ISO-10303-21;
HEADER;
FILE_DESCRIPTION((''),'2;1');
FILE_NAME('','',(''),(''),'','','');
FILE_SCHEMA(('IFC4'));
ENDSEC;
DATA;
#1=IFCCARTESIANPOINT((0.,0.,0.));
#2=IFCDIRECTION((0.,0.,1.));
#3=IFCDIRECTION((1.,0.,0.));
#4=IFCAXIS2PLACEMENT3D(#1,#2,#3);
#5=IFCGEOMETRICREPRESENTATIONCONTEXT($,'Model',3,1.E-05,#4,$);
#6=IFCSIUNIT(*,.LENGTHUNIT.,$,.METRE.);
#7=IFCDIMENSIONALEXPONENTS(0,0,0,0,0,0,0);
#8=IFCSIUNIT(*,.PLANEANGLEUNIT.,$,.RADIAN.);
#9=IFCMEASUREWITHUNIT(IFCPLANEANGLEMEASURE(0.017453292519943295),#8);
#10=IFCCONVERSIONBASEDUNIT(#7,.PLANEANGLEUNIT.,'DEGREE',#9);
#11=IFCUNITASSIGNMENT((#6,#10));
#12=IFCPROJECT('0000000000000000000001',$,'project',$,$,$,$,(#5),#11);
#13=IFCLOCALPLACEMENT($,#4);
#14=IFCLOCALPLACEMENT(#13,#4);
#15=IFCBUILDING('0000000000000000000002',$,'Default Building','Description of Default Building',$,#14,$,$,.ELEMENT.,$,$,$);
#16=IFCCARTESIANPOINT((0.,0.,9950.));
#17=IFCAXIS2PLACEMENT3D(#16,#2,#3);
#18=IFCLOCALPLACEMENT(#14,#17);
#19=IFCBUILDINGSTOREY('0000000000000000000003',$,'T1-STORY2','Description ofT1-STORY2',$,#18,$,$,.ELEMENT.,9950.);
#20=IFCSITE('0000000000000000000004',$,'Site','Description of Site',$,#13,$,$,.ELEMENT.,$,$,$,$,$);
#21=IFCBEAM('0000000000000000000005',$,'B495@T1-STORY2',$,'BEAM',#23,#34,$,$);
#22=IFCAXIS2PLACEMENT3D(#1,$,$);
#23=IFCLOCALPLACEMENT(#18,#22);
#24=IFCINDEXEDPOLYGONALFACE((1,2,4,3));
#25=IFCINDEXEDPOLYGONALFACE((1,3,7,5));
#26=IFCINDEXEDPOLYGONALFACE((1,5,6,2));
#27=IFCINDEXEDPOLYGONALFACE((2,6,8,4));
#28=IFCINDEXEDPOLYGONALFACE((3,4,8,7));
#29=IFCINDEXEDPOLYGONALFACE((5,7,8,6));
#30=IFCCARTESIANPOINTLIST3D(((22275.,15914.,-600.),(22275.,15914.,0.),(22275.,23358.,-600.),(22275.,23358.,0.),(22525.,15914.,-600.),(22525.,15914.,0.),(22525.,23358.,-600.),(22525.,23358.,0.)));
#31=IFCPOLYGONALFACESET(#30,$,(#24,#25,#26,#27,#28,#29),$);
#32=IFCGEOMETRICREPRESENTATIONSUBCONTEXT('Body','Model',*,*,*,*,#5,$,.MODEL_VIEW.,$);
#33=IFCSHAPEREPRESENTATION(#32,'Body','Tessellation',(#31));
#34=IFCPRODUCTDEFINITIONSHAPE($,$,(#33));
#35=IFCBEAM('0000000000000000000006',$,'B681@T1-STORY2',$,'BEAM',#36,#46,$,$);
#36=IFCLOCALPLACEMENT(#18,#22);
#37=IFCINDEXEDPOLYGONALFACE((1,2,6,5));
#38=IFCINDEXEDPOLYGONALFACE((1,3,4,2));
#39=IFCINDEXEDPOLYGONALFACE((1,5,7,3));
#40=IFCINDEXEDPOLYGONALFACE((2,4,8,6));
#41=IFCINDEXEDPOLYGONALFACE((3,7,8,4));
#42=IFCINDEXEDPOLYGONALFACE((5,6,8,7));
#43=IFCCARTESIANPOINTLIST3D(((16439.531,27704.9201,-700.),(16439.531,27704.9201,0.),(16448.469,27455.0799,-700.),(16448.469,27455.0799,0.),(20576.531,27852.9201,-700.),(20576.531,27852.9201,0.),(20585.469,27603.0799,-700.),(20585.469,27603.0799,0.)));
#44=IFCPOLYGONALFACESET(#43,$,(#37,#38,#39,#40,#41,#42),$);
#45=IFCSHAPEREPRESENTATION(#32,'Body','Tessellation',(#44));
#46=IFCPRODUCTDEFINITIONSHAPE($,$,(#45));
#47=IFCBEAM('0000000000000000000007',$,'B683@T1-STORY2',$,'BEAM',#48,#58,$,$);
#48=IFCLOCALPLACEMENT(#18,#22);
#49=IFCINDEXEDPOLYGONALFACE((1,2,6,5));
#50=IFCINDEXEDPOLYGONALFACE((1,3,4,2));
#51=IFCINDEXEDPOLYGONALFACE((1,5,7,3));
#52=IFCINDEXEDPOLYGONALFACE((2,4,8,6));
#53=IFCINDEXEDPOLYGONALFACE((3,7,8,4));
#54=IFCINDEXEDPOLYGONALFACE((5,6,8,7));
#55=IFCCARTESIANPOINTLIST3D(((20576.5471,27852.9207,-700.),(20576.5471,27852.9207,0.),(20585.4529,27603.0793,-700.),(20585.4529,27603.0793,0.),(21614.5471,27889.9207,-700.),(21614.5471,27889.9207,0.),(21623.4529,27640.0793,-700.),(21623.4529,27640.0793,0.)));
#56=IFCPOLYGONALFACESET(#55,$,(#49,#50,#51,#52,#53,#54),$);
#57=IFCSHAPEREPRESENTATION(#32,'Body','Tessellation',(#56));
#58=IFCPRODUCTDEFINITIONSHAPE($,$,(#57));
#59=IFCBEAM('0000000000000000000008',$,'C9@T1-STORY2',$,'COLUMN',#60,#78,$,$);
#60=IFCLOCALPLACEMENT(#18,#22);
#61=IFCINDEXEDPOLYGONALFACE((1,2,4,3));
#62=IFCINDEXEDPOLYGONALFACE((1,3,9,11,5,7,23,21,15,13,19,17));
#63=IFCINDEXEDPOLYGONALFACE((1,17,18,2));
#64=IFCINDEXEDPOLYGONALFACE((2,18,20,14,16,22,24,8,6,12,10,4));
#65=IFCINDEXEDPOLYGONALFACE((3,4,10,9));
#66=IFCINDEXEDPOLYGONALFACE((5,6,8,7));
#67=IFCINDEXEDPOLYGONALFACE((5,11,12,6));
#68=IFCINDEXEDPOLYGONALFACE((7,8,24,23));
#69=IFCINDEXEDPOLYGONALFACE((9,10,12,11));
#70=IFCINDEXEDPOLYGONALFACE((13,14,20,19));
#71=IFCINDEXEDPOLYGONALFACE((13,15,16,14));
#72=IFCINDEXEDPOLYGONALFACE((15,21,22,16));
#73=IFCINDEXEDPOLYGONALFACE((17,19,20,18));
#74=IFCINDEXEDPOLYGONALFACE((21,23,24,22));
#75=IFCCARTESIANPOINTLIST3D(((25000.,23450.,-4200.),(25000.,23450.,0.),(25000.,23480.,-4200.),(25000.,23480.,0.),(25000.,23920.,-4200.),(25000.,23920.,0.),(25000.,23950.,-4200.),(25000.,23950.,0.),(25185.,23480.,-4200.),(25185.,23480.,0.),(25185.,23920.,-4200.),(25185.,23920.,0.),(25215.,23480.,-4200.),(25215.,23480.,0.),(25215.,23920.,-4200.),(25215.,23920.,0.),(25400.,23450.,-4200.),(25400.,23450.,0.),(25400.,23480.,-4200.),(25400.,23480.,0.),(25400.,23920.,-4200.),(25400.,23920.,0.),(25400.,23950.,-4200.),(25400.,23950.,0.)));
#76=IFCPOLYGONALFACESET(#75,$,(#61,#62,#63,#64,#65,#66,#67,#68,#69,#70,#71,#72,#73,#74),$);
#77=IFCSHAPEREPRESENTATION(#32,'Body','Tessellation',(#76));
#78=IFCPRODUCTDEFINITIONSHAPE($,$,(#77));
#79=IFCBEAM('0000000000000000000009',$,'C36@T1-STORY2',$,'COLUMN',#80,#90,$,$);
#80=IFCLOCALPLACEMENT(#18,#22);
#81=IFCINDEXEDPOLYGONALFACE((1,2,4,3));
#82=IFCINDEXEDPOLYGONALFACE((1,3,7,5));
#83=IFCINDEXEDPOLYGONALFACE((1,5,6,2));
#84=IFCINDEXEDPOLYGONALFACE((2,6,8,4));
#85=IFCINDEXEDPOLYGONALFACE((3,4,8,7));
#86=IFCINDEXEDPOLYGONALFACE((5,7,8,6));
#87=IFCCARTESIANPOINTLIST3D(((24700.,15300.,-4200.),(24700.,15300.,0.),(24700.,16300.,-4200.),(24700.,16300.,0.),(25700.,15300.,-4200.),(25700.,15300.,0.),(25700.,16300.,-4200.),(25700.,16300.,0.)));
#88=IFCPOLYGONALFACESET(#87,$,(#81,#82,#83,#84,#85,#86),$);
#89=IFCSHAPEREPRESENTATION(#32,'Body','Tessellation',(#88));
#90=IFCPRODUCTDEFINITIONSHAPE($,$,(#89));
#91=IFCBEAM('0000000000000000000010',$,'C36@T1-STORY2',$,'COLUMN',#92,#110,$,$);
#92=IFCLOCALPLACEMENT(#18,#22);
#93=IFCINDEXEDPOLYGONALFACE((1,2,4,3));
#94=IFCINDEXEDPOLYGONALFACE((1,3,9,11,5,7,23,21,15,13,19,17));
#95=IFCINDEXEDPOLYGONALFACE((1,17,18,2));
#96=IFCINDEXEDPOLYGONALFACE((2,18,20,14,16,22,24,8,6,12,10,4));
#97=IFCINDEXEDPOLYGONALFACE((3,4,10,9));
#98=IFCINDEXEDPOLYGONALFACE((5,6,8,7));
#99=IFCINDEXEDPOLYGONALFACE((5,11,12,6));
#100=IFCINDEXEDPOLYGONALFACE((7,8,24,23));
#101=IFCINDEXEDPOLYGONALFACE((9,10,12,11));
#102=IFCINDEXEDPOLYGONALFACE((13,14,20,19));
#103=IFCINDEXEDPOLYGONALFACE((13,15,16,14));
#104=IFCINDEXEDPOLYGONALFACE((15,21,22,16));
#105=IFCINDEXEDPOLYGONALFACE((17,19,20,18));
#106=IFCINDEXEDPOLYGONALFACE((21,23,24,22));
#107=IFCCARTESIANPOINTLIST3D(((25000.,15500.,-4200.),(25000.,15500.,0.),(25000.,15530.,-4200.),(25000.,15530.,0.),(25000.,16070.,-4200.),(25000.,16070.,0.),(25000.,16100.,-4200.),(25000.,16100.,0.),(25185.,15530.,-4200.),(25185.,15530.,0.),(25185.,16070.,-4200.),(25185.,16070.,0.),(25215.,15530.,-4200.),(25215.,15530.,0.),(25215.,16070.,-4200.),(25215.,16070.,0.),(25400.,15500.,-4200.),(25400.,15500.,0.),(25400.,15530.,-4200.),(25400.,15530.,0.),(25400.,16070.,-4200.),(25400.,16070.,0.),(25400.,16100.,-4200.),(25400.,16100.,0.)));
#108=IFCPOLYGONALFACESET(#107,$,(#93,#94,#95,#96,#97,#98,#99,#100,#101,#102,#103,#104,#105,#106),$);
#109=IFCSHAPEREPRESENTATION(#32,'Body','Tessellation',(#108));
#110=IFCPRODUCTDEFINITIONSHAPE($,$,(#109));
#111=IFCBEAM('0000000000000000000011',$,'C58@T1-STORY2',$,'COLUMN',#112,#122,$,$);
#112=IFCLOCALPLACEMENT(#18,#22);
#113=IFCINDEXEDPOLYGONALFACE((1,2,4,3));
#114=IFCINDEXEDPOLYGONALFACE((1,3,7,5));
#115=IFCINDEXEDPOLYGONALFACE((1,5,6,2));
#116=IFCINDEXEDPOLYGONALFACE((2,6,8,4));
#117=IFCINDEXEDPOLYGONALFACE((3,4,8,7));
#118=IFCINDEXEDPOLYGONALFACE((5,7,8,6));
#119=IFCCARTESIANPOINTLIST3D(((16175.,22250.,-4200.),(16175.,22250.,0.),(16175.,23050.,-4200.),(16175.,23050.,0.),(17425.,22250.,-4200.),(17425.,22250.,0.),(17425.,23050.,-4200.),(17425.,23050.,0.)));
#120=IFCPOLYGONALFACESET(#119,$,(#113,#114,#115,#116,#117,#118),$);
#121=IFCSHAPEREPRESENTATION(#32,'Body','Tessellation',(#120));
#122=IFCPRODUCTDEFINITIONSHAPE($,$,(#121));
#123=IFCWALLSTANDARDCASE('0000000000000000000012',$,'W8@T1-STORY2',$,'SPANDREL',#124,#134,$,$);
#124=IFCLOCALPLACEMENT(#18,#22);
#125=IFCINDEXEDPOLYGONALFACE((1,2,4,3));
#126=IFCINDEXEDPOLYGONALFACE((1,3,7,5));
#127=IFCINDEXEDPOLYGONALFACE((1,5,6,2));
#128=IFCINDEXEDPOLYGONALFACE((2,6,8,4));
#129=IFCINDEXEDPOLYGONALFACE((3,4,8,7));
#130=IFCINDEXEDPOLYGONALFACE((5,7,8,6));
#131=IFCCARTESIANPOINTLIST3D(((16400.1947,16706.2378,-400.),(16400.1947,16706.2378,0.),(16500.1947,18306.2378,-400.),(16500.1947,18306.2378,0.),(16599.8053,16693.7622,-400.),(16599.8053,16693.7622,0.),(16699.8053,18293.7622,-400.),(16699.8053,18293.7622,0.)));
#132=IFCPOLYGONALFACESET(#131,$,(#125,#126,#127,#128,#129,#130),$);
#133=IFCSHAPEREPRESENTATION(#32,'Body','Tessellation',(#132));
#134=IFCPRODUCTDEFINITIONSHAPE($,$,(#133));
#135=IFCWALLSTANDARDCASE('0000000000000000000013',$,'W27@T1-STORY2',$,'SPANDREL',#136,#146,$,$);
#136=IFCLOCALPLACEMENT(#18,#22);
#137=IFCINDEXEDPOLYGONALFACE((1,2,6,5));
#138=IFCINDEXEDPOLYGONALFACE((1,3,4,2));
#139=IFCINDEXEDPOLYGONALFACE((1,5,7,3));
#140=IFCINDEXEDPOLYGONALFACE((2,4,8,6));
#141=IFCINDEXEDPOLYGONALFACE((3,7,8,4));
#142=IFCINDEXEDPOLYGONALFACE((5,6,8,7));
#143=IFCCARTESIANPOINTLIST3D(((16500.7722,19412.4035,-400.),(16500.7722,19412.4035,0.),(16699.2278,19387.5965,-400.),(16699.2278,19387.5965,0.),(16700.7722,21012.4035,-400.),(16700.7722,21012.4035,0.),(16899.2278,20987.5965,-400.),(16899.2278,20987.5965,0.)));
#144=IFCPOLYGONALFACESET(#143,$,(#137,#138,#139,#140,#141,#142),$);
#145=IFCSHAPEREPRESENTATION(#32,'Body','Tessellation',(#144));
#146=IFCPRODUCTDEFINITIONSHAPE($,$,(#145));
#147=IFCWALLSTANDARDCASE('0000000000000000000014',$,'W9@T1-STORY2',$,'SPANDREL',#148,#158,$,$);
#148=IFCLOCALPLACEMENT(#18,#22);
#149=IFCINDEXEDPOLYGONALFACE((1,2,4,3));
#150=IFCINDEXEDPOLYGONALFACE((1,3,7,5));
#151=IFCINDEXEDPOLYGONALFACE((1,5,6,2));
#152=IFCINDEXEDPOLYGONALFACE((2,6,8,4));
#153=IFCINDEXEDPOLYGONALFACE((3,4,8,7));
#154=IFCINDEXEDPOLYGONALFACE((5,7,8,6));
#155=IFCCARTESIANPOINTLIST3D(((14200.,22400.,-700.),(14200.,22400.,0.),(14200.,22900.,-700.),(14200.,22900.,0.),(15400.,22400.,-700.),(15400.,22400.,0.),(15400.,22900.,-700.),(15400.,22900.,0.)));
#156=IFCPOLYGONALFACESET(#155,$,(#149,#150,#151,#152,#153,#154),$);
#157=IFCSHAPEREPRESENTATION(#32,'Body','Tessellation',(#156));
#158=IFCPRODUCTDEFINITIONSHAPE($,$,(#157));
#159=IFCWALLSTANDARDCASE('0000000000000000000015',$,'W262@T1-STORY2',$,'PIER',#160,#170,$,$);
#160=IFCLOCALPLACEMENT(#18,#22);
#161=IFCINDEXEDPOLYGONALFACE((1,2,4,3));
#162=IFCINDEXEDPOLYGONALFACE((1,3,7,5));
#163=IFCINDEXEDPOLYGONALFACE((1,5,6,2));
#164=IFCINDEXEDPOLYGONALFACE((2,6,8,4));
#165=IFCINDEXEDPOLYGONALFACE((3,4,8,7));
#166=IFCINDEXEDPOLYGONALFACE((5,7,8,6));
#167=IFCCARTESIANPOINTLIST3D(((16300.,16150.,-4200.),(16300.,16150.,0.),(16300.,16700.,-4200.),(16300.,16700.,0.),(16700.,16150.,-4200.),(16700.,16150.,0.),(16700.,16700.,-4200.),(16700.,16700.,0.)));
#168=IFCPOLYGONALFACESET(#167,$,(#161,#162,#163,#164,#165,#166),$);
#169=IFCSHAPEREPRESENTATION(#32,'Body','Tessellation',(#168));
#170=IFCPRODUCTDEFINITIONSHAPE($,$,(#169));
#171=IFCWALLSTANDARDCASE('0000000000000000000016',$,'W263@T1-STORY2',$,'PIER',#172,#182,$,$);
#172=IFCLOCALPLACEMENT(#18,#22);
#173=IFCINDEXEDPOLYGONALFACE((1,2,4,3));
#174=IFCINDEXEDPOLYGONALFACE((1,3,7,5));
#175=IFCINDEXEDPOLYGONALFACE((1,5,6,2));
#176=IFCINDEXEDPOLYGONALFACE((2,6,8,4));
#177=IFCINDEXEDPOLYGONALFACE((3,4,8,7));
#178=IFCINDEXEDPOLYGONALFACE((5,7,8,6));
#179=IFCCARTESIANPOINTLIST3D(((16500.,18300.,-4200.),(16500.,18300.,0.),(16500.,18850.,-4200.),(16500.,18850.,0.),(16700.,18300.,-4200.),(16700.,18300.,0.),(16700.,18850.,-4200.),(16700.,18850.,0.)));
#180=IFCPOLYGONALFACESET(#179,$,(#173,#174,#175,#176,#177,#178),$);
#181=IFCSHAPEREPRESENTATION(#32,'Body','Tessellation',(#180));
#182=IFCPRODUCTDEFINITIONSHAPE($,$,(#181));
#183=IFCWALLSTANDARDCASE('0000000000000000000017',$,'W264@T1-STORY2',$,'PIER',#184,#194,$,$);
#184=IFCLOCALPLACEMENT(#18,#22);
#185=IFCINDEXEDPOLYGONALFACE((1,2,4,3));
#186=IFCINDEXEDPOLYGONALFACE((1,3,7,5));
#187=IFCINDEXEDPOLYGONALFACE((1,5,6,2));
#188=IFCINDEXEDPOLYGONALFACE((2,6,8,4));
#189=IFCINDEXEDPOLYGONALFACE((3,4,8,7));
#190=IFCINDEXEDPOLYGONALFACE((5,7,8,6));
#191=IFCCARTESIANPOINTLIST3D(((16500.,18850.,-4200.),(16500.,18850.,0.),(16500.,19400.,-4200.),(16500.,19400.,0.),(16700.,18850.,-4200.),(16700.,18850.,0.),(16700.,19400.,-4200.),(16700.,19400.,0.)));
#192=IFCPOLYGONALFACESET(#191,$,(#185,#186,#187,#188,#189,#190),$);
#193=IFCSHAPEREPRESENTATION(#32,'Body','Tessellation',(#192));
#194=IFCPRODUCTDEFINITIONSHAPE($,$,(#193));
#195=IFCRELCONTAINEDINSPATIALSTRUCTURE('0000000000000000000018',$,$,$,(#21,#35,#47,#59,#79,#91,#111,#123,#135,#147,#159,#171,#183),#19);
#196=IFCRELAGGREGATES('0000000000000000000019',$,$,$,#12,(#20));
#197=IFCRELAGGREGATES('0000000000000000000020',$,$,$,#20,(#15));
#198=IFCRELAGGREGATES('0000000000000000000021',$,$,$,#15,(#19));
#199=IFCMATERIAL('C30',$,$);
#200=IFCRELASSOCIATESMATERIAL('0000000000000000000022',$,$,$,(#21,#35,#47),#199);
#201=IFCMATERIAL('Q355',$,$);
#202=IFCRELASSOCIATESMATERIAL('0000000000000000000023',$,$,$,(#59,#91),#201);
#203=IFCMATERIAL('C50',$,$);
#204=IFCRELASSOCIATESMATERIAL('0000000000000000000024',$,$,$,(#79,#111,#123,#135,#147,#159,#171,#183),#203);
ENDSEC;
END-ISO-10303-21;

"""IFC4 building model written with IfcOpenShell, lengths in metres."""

from ifc_helpers import new_model, entity, si_unit, converted_unit, frame, origin_with_axes, place, context, subcontext, project, spatial, indexed_curve, rectangle, i_section, outline, extrude, material, element, save


model = new_model("IFC4")

# Units and contexts
model_context = context("Model", 3, precision=1e-05, world=origin_with_axes())
body_context = subcontext(model_context, "Body", "Model", "MODEL_VIEW")
ifc_project = project(units=[si_unit("LENGTHUNIT", "METRE"), converted_unit("PLANEANGLEUNIT", "DEGREE", entity("IfcPlaneAngleMeasure", 0.017453292519943295), si_unit("PLANEANGLEUNIT", "RADIAN"), dimensions=[0, 0, 0, 0, 0, 0, 0])], contexts=[model_context])

# Site, building, storey
site_placement = place(None, origin_with_axes())
site = spatial("IfcSite", under=ifc_project, at=site_placement, Name="Site", Description="Description of Site", CompositionType="ELEMENT")
building_placement = place(site_placement, origin_with_axes())
building = spatial("IfcBuilding", under=site, at=building_placement, Name="Default Building", Description="Description of Default Building", CompositionType="ELEMENT")
storey_placement = place(building_placement, frame((0.0, 0.0, 9950.0), z_axis=(0.0, 0.0, 1.0), x_axis=(1.0, 0.0, 0.0)))
storey = spatial("IfcBuildingStorey", under=building, at=storey_placement, Name="T1-STORY2", Description="Description ofT1-STORY2", CompositionType="ELEMENT", Elevation=9950.0)

# Beams
ifc_material_1 = material(Name="C30")
beam_1_placement = place(storey_placement, frame((22400.0, 15914.0, -300.0), z_axis=(0.0, 1.0, 0.0), x_axis=(-1.0, 0.0, 0.0)))
element("IfcBeam", 1, at=beam_1_placement, inside=storey, material=ifc_material_1, Name="B495@T1-STORY2", ObjectType="BEAM", context=body_context, shape_type="SweptSolid", body=[
    extrude(rectangle(XDim=250.0, YDim=600.0), origin_with_axes(), (0.0, 0.0, 1.0), 7444.0),
])
beam_2_placement = place(storey_placement, frame((16444.0, 27580.0, -350.0), z_axis=(0.999361, 0.035752, 0.0), x_axis=(-0.035752, 0.999361, 0.0)))
element("IfcBeam", 2, at=beam_2_placement, inside=storey, material=ifc_material_1, Name="B681@T1-STORY2", ObjectType="BEAM", context=body_context, shape_type="SweptSolid", body=[
    extrude(rectangle(XDim=250.0, YDim=700.0), origin_with_axes(), (0.0, 0.0, 1.0), 4139.6465),
])
beam_3_placement = place(storey_placement, frame((20581.0, 27728.0, -350.0), z_axis=(0.999365, 0.035623, 0.0), x_axis=(-0.035623, 0.999365, 0.0)))
element("IfcBeam", 3, at=beam_3_placement, inside=storey, material=ifc_material_1, Name="B683@T1-STORY2", ObjectType="BEAM", context=body_context, shape_type="SweptSolid", body=[
    extrude(rectangle(XDim=250.0, YDim=700.0), origin_with_axes(), (0.0, 0.0, 1.0), 1038.6592),
])
ifc_material_2 = material(Name="C50")
ifc_material_3 = material(Name="Q355")
beam_4_placement = place(storey_placement, frame((25200.0, 23700.0, -4200.0), z_axis=(0.0, 0.0, 1.0), x_axis=(-1.0, 0.0, 0.0)))
element("IfcBeam", 4, at=beam_4_placement, inside=storey, material=ifc_material_3, Name="C9@T1-STORY2", ObjectType="COLUMN", context=body_context, shape_type="SweptSolid", body=[
    extrude(i_section(OverallWidth=400.0, OverallDepth=500.0, WebThickness=30.0, FlangeThickness=30.0, FilletRadius=0.0), origin_with_axes(), (0.0, 0.0, 1.0), 4200.0),
])
beam_5_placement = place(storey_placement, frame((25200.0, 15800.0, -4200.0), z_axis=(0.0, 0.0, 1.0), x_axis=(-1.0, 0.0, 0.0)))
element("IfcBeam", 5, at=beam_5_placement, inside=storey, material=ifc_material_2, Name="C36@T1-STORY2", ObjectType="COLUMN", context=body_context, shape_type="SweptSolid", body=[
    extrude(rectangle(XDim=1000.0, YDim=1000.0), origin_with_axes(), (0.0, 0.0, 1.0), 4200.0),
])
beam_6_placement = place(storey_placement, frame((25200.0, 15800.0, -4200.0), z_axis=(0.0, 0.0, 1.0), x_axis=(-1.0, 0.0, 0.0)))
element("IfcBeam", 6, at=beam_6_placement, inside=storey, material=ifc_material_3, Name="C36@T1-STORY2", ObjectType="COLUMN", context=body_context, shape_type="SweptSolid", body=[
    extrude(i_section(OverallWidth=400.0, OverallDepth=600.0, WebThickness=30.0, FlangeThickness=30.0, FilletRadius=0.0), origin_with_axes(), (0.0, 0.0, 1.0), 4200.0),
])
beam_7_placement = place(storey_placement, frame((16800.0, 22650.0, -4200.0), z_axis=(0.0, 0.0, 1.0), x_axis=(0.0, -1.0, 0.0)))
element("IfcBeam", 7, at=beam_7_placement, inside=storey, material=ifc_material_2, Name="C58@T1-STORY2", ObjectType="COLUMN", context=body_context, shape_type="SweptSolid", body=[
    extrude(rectangle(XDim=800.0, YDim=1250.0), origin_with_axes(), (0.0, 0.0, 1.0), 4200.0),
])

# Walls
wall_1_placement = place(storey_placement, frame((16500.0, 16700.0, -400.0), z_axis=(0.0, 0.0, 1.0), x_axis=(0.062378, 0.998053, 0.0)))
element("IfcWallStandardCase", 8, at=wall_1_placement, inside=storey, material=ifc_material_2, Name="W8@T1-STORY2", ObjectType="SPANDREL", context=body_context, shape_type="SweptSolid", body=[
    extrude(outline(indexed_curve([(0.0, -100.0), (0.0, 100.0), (1603.122, 100.0), (1603.122, -100.0), (0.0, -100.0)], self_intersect=False)), origin_with_axes(), (0.0, 0.0, 1.0), 400.0),
])
wall_2_placement = place(storey_placement, frame((16600.0, 19400.0, -400.0), z_axis=(0.0, 0.0, 1.0), x_axis=(0.124035, 0.992278, 0.0)))
element("IfcWallStandardCase", 9, at=wall_2_placement, inside=storey, material=ifc_material_2, Name="W27@T1-STORY2", ObjectType="SPANDREL", context=body_context, shape_type="SweptSolid", body=[
    extrude(outline(indexed_curve([(0.0, -100.0), (0.0, 100.0), (1612.4515, 100.0), (1612.4515, -100.0), (0.0, -100.0)], self_intersect=False)), origin_with_axes(), (0.0, 0.0, 1.0), 400.0),
])
wall_3_placement = place(storey_placement, frame((14200.0, 22650.0, -700.0), z_axis=(0.0, 0.0, 1.0), x_axis=(1.0, 0.0, 0.0)))
element("IfcWallStandardCase", 10, at=wall_3_placement, inside=storey, material=ifc_material_2, Name="W9@T1-STORY2", ObjectType="SPANDREL", context=body_context, shape_type="SweptSolid", body=[
    extrude(outline(indexed_curve([(0.0, -250.0), (0.0, 250.0), (1200.0, 250.0), (1200.0, -250.0), (0.0, -250.0)], self_intersect=False)), origin_with_axes(), (0.0, 0.0, 1.0), 700.0),
])
wall_4_placement = place(storey_placement, frame((16500.0, 16150.0, -4200.0), z_axis=(0.0, 0.0, 1.0), x_axis=(0.0, 1.0, 0.0)))
element("IfcWallStandardCase", 11, at=wall_4_placement, inside=storey, material=ifc_material_2, Name="W262@T1-STORY2", ObjectType="PIER", context=body_context, shape_type="SweptSolid", body=[
    extrude(outline(indexed_curve([(0.0, -200.0), (0.0, 200.0), (550.0, 200.0), (550.0, -200.0), (0.0, -200.0)], self_intersect=False)), origin_with_axes(), (0.0, 0.0, 1.0), 4200.0),
])
for number, where, z_axis, x_axis, name in (
    (12, (16600.0, 18300.0, -4200.0), (0.0, 0.0, 1.0), (0.0, 1.0, 0.0), "W263@T1-STORY2"),
    (13, (16600.0, 18850.0, -4200.0), (0.0, 0.0, 1.0), (0.0, 1.0, 0.0), "W264@T1-STORY2"),
):
    element("IfcWallStandardCase", number, at=place(storey_placement, frame(where, z_axis=z_axis, x_axis=x_axis)), inside=storey, material=ifc_material_2, Name=name, ObjectType="PIER", context=body_context, shape_type="SweptSolid", body=[
        extrude(outline(indexed_curve([(0.0, -100.0), (0.0, 100.0), (550.0, 100.0), (550.0, -100.0), (0.0, -100.0)], self_intersect=False)), origin_with_axes(), (0.0, 0.0, 1.0), 4200.0),
    ])

save(model, "model.ifc")
